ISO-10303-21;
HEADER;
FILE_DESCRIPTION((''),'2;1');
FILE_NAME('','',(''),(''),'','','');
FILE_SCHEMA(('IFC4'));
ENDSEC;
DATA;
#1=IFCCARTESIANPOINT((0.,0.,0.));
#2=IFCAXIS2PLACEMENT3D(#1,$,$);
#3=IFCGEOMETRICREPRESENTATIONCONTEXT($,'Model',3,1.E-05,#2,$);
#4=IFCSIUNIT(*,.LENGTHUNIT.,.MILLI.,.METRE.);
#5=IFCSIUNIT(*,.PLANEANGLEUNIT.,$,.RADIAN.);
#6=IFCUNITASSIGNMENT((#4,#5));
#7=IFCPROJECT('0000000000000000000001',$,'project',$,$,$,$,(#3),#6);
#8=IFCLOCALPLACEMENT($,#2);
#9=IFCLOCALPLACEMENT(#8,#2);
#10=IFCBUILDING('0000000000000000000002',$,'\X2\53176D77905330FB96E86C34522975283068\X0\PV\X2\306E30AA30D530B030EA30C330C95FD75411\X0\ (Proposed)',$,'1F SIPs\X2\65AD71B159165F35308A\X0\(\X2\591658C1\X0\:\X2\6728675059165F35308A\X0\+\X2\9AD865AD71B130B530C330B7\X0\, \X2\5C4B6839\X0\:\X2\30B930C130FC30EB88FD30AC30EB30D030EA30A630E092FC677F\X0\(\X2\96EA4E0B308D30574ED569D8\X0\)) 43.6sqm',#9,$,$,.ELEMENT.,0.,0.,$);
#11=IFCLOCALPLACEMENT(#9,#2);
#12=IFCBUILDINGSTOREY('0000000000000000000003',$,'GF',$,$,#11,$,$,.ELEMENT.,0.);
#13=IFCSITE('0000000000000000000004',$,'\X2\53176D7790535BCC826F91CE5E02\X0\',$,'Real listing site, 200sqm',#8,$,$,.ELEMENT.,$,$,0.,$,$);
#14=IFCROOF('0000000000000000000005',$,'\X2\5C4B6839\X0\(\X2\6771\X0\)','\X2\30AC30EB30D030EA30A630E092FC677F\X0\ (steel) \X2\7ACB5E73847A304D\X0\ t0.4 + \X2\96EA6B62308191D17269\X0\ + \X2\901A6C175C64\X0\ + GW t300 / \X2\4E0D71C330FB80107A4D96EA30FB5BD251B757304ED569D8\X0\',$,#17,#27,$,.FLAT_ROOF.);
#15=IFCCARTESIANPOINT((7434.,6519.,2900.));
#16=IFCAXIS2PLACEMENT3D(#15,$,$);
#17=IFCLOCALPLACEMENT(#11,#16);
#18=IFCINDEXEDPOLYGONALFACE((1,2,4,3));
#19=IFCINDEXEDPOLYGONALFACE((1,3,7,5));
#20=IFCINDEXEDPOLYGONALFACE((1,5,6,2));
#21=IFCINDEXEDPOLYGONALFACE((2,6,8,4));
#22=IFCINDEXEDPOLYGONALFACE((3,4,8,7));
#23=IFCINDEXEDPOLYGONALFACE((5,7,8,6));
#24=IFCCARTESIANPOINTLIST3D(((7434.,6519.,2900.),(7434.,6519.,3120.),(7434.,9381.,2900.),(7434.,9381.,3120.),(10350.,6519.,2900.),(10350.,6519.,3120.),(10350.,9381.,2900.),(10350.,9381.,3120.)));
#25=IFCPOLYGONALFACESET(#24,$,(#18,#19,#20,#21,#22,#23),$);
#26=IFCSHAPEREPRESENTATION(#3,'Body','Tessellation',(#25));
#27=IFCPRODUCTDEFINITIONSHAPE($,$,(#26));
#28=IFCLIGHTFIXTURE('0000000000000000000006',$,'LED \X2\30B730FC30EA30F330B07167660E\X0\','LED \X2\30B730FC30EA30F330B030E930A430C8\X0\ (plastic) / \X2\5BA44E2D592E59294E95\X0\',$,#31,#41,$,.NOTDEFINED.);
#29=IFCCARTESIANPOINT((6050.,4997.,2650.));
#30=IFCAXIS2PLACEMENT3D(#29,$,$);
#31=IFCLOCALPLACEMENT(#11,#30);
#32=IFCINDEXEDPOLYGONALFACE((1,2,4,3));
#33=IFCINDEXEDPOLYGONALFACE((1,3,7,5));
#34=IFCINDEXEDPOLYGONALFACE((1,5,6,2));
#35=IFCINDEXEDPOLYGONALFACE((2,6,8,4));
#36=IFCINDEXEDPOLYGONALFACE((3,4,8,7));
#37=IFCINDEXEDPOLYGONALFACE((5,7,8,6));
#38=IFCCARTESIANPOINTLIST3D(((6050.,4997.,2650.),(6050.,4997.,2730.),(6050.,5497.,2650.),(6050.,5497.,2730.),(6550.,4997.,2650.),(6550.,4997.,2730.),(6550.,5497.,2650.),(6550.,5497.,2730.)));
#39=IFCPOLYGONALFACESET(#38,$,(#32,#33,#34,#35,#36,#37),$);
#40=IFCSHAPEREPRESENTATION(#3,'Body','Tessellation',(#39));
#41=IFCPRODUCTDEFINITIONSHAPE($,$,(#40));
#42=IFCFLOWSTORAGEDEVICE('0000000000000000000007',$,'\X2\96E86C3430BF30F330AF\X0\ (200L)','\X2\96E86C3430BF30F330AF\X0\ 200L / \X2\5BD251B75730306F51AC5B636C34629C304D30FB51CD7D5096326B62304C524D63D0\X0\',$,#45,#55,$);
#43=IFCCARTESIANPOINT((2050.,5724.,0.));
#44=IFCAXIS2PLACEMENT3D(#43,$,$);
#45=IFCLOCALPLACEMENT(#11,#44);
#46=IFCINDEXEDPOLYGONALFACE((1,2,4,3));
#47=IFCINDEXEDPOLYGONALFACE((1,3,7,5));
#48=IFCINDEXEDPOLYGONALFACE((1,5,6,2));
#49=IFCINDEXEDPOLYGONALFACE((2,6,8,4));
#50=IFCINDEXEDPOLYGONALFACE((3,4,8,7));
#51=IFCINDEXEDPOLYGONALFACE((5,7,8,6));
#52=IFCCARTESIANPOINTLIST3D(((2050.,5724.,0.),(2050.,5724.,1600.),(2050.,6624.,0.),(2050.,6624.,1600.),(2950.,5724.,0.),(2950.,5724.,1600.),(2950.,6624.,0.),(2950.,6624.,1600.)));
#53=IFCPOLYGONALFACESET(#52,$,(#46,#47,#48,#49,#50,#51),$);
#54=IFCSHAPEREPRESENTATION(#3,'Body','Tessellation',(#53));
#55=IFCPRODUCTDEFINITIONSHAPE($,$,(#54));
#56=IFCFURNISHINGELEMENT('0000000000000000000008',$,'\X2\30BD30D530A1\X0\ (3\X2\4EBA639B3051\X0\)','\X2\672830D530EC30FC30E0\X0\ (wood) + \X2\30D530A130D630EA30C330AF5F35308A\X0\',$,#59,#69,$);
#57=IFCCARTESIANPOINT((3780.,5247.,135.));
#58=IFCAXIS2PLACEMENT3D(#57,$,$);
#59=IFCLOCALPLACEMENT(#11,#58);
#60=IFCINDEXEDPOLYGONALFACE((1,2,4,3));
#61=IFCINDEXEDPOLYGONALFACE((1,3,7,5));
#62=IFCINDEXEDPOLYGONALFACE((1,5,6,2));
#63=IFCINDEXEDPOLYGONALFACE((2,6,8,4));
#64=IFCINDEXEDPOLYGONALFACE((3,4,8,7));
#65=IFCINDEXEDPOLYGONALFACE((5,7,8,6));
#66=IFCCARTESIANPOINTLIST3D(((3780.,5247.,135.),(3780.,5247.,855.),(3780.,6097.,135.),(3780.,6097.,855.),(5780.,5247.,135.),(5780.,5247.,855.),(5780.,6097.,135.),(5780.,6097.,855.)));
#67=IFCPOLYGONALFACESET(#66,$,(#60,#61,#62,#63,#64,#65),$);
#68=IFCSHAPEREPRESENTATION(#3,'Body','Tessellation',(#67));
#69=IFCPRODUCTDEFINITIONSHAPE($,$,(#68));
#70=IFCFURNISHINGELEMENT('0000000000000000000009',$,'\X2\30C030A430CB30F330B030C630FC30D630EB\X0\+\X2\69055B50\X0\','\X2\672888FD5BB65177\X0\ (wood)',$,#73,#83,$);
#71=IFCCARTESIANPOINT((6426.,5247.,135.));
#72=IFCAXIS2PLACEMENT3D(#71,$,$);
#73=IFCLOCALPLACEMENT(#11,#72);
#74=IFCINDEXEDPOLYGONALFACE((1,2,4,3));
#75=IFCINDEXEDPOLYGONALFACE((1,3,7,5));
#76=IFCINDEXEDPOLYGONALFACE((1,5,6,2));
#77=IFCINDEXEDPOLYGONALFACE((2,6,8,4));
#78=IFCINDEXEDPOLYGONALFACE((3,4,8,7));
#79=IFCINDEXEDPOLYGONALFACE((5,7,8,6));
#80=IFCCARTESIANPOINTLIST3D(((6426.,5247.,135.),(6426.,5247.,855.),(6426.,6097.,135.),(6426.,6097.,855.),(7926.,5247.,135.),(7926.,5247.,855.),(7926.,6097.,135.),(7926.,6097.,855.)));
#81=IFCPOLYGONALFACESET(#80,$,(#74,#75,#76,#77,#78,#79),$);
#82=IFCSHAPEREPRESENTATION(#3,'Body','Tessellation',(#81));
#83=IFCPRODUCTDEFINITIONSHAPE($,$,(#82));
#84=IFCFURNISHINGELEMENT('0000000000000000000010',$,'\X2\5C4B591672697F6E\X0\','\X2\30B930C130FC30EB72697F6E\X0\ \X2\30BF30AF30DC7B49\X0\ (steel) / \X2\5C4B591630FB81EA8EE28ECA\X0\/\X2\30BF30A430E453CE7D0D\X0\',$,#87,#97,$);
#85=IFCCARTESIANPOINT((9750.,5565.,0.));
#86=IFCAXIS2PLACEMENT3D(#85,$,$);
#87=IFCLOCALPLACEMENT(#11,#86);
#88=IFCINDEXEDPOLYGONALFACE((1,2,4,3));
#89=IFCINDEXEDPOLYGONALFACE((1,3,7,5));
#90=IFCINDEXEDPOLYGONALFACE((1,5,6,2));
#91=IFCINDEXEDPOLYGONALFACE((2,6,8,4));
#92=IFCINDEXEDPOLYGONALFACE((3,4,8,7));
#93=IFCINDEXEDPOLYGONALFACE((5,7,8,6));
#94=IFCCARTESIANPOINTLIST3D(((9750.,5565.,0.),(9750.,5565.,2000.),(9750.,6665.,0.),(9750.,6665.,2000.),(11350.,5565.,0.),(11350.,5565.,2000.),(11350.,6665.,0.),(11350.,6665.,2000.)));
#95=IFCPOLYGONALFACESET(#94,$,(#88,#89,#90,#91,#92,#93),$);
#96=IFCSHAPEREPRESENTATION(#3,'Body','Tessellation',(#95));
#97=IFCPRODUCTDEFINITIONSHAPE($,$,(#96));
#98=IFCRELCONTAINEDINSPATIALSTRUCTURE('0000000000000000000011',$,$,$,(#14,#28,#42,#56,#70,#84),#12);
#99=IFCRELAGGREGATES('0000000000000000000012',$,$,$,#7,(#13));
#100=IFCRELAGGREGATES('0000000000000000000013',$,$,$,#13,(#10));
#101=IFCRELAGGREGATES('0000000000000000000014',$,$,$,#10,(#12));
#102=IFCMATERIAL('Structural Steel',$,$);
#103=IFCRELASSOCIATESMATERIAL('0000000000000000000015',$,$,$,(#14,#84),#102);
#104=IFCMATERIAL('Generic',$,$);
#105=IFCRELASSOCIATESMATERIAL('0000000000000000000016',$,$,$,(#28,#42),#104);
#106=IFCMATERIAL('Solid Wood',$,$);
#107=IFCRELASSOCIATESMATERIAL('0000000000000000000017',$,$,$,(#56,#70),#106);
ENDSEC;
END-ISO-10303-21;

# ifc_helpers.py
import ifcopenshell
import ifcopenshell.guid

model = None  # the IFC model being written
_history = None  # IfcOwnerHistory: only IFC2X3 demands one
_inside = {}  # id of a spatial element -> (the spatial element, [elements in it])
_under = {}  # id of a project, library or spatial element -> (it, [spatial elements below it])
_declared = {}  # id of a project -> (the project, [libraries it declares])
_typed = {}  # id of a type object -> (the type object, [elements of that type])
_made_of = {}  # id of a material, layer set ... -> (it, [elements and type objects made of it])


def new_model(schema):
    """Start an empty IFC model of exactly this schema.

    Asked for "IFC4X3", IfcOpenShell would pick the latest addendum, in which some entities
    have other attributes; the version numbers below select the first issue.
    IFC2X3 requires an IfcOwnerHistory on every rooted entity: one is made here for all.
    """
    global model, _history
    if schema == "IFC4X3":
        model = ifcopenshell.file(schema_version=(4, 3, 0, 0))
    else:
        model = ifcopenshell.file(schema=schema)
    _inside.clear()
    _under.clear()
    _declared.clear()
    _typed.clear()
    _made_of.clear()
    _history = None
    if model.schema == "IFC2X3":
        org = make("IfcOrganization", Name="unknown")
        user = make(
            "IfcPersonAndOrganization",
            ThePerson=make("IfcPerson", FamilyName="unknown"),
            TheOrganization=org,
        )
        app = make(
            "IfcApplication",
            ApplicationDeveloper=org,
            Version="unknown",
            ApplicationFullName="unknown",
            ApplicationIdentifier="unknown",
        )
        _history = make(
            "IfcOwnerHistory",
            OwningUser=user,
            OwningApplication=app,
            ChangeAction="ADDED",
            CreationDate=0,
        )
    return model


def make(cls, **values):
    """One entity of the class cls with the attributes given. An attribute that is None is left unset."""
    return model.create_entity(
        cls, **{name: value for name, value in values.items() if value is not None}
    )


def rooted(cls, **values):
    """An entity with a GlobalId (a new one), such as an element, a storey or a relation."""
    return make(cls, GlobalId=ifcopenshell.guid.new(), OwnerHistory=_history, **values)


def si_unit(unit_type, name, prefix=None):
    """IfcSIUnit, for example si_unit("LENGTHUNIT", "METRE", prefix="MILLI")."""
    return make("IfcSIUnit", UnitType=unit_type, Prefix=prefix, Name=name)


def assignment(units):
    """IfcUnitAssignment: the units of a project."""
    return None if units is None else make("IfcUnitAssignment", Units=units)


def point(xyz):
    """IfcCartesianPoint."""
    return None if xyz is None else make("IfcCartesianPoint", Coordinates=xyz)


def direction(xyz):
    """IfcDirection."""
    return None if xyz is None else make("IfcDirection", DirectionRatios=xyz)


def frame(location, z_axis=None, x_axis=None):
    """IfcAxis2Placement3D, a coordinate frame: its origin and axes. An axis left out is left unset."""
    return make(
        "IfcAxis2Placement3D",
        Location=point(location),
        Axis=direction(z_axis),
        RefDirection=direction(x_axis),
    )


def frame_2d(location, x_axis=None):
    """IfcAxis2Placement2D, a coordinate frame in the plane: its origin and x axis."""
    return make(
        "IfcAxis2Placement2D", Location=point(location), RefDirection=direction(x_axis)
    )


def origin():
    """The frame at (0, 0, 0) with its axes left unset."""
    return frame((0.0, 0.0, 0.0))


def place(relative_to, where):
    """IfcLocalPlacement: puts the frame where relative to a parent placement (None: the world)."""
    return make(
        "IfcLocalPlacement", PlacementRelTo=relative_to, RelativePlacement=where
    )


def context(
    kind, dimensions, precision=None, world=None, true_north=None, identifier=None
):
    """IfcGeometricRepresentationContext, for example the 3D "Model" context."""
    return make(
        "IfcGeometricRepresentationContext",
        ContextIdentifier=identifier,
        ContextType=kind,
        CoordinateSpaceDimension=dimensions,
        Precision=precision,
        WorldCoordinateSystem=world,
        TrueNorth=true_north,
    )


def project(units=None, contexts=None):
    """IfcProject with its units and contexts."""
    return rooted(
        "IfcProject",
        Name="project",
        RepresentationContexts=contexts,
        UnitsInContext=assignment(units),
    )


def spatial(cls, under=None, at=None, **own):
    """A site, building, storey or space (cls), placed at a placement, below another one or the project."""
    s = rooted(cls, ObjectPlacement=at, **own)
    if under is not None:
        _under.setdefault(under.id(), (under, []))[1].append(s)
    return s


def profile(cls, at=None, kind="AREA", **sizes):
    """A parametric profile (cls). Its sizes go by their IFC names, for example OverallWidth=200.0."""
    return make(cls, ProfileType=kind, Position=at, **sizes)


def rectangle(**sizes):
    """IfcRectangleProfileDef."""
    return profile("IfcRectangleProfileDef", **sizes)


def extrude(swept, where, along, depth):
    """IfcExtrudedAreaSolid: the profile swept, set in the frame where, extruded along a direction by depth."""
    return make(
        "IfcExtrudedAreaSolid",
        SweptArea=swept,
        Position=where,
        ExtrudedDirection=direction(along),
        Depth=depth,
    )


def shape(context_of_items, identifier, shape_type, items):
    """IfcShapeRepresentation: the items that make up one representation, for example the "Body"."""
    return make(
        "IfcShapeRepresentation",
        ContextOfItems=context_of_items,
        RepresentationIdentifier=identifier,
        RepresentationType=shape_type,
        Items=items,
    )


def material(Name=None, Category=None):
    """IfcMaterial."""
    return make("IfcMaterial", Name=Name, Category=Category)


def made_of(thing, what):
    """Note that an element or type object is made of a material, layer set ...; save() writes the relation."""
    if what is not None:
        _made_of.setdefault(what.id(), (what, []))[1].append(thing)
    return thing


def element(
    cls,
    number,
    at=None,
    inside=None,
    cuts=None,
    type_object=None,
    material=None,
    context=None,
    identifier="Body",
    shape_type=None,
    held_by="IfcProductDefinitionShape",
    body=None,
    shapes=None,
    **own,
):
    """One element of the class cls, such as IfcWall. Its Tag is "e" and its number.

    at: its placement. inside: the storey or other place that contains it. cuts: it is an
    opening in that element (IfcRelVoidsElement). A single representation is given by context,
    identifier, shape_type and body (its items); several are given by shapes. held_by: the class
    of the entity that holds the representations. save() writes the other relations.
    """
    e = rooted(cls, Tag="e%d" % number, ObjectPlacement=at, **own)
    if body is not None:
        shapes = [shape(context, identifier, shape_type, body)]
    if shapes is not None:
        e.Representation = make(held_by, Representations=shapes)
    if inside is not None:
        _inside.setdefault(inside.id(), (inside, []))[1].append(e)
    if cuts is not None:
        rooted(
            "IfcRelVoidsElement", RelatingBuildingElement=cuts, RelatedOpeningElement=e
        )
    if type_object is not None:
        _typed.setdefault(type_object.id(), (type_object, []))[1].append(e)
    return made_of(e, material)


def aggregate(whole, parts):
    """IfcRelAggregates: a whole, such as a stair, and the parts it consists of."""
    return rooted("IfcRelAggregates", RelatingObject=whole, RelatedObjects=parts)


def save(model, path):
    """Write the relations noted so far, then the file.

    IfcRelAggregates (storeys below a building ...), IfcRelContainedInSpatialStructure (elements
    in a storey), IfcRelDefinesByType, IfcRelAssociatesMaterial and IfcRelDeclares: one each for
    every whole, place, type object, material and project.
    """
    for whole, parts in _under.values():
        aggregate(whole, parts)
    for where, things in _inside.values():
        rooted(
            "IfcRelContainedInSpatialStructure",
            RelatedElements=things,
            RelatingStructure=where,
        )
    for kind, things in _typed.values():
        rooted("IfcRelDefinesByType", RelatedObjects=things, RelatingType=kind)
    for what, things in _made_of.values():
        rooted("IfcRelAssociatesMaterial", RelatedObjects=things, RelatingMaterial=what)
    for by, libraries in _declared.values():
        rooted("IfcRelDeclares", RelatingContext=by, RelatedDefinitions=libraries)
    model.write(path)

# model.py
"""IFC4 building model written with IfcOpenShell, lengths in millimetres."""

from ifc_helpers import new_model, si_unit, frame, frame_2d, origin, place, context, project, spatial, rectangle, extrude, material, element, save


model = new_model("IFC4")

# Units and contexts
model_context = context("Model", 3, precision=1e-05, world=origin())
ifc_project = project(units=[si_unit("LENGTHUNIT", "METRE", prefix="MILLI"), si_unit("PLANEANGLEUNIT", "RADIAN")], contexts=[model_context])

# Site, building, storey
site_placement = place(None, origin())
site = spatial("IfcSite", under=ifc_project, at=site_placement, Name="北海道富良野市", ObjectType="Real listing site, 200sqm", CompositionType="ELEMENT", RefElevation=0.0)
building_placement = place(site_placement, origin())
building = spatial("IfcBuilding", under=site, at=building_placement, Name="北海道・雨水利用とPVのオフグリッド志向 (Proposed)", ObjectType="1F SIPs断熱外張り(外壁:木材外張り+高断熱サッシ, 屋根:スチール製ガルバリウム鋼板(雪下ろし仕様)) 43.6sqm", CompositionType="ELEMENT", ElevationOfRefHeight=0.0, ElevationOfTerrain=0.0)
storey_placement = place(building_placement, origin())
storey = spatial("IfcBuildingStorey", under=building, at=storey_placement, Name="GF", CompositionType="ELEMENT", Elevation=0.0)

# Shared definitions
ifc_material_1 = material(Name="Solid Wood")

# Roof
ifc_material_2 = material(Name="Structural Steel")
roof_1_placement = place(storey_placement, frame((7434.0, 6519.0, 2900.0)))
element("IfcRoof", 1, at=roof_1_placement, inside=storey, material=ifc_material_2, Name="屋根(東)", Description="ガルバリウム鋼板 (steel) 立平葺き t0.4 + 雪止め金物 + 通気層 + GW t300 / 不燃・耐積雪・寒冷地仕様", PredefinedType="FLAT_ROOF", context=model_context, shape_type="SweptSolid", body=[
    extrude(rectangle(XDim=2916.0, YDim=2862.0, at=frame_2d((1458.0, 1431.0))), frame((7434.0, 6519.0, 2900.0)), (0.0, 0.0, 1.0), 220.0),
])

# Light fixture
ifc_material_3 = material(Name="Generic")
light_fixture_placement = place(storey_placement, frame((6050.0, 4997.0, 2650.0)))
element("IfcLightFixture", 2, at=light_fixture_placement, inside=storey, material=ifc_material_3, Name="LED シーリング照明", Description="LED シーリングライト (plastic) / 室中央天井", PredefinedType="NOTDEFINED", context=model_context, shape_type="SweptSolid", body=[
    extrude(rectangle(XDim=500.0, YDim=500.0, at=frame_2d((250.0, 250.0))), frame((6050.0, 4997.0, 2650.0)), (0.0, 0.0, 1.0), 80.0),
])

# Flow storage device
flow_storage_device_placement = place(storey_placement, frame((2050.0, 5724.0, 0.0)))
element("IfcFlowStorageDevice", 3, at=flow_storage_device_placement, inside=storey, material=ifc_material_3, Name="雨水タンク (200L)", Description="雨水タンク 200L / 寒冷地は冬季水抜き・凍結防止が前提", context=model_context, shape_type="SweptSolid", body=[
    extrude(rectangle(XDim=900.0, YDim=900.0, at=frame_2d((450.0, 450.0))), frame((2050.0, 5724.0, 0.0)), (0.0, 0.0, 1.0), 1600.0),
])

# Furnishing elements
furnishing_1_placement = place(storey_placement, frame((3780.0, 5247.0, 135.0)))
element("IfcFurnishingElement", 4, at=furnishing_1_placement, inside=storey, material=ifc_material_1, Name="ソファ (3人掛け)", Description="木フレーム (wood) + ファブリック張り", context=model_context, shape_type="SweptSolid", body=[
    extrude(rectangle(XDim=2000.0, YDim=850.0, at=frame_2d((1000.0, 425.0))), frame((3780.0, 5247.0, 135.0)), (0.0, 0.0, 1.0), 720.0),
])
furnishing_2_placement = place(storey_placement, frame((6426.0, 5247.0, 135.0)))
element("IfcFurnishingElement", 5, at=furnishing_2_placement, inside=storey, material=ifc_material_1, Name="ダイニングテーブル+椅子", Description="木製家具 (wood)", context=model_context, shape_type="SweptSolid", body=[
    extrude(rectangle(XDim=1500.0, YDim=850.0, at=frame_2d((750.0, 425.0))), frame((6426.0, 5247.0, 135.0)), (0.0, 0.0, 1.0), 720.0),
])
furnishing_3_placement = place(storey_placement, frame((9750.0, 5565.0, 0.0)))
element("IfcFurnishingElement", 6, at=furnishing_3_placement, inside=storey, material=ifc_material_2, Name="屋外物置", Description="スチール物置 タクボ等 (steel) / 屋外・自転車/タイヤ収納", context=model_context, shape_type="SweptSolid", body=[
    extrude(rectangle(XDim=1600.0, YDim=1100.0, at=frame_2d((800.0, 550.0))), frame((9750.0, 5565.0, 0.0)), (0.0, 0.0, 1.0), 2000.0),
])

save(model, "model.ifc")
